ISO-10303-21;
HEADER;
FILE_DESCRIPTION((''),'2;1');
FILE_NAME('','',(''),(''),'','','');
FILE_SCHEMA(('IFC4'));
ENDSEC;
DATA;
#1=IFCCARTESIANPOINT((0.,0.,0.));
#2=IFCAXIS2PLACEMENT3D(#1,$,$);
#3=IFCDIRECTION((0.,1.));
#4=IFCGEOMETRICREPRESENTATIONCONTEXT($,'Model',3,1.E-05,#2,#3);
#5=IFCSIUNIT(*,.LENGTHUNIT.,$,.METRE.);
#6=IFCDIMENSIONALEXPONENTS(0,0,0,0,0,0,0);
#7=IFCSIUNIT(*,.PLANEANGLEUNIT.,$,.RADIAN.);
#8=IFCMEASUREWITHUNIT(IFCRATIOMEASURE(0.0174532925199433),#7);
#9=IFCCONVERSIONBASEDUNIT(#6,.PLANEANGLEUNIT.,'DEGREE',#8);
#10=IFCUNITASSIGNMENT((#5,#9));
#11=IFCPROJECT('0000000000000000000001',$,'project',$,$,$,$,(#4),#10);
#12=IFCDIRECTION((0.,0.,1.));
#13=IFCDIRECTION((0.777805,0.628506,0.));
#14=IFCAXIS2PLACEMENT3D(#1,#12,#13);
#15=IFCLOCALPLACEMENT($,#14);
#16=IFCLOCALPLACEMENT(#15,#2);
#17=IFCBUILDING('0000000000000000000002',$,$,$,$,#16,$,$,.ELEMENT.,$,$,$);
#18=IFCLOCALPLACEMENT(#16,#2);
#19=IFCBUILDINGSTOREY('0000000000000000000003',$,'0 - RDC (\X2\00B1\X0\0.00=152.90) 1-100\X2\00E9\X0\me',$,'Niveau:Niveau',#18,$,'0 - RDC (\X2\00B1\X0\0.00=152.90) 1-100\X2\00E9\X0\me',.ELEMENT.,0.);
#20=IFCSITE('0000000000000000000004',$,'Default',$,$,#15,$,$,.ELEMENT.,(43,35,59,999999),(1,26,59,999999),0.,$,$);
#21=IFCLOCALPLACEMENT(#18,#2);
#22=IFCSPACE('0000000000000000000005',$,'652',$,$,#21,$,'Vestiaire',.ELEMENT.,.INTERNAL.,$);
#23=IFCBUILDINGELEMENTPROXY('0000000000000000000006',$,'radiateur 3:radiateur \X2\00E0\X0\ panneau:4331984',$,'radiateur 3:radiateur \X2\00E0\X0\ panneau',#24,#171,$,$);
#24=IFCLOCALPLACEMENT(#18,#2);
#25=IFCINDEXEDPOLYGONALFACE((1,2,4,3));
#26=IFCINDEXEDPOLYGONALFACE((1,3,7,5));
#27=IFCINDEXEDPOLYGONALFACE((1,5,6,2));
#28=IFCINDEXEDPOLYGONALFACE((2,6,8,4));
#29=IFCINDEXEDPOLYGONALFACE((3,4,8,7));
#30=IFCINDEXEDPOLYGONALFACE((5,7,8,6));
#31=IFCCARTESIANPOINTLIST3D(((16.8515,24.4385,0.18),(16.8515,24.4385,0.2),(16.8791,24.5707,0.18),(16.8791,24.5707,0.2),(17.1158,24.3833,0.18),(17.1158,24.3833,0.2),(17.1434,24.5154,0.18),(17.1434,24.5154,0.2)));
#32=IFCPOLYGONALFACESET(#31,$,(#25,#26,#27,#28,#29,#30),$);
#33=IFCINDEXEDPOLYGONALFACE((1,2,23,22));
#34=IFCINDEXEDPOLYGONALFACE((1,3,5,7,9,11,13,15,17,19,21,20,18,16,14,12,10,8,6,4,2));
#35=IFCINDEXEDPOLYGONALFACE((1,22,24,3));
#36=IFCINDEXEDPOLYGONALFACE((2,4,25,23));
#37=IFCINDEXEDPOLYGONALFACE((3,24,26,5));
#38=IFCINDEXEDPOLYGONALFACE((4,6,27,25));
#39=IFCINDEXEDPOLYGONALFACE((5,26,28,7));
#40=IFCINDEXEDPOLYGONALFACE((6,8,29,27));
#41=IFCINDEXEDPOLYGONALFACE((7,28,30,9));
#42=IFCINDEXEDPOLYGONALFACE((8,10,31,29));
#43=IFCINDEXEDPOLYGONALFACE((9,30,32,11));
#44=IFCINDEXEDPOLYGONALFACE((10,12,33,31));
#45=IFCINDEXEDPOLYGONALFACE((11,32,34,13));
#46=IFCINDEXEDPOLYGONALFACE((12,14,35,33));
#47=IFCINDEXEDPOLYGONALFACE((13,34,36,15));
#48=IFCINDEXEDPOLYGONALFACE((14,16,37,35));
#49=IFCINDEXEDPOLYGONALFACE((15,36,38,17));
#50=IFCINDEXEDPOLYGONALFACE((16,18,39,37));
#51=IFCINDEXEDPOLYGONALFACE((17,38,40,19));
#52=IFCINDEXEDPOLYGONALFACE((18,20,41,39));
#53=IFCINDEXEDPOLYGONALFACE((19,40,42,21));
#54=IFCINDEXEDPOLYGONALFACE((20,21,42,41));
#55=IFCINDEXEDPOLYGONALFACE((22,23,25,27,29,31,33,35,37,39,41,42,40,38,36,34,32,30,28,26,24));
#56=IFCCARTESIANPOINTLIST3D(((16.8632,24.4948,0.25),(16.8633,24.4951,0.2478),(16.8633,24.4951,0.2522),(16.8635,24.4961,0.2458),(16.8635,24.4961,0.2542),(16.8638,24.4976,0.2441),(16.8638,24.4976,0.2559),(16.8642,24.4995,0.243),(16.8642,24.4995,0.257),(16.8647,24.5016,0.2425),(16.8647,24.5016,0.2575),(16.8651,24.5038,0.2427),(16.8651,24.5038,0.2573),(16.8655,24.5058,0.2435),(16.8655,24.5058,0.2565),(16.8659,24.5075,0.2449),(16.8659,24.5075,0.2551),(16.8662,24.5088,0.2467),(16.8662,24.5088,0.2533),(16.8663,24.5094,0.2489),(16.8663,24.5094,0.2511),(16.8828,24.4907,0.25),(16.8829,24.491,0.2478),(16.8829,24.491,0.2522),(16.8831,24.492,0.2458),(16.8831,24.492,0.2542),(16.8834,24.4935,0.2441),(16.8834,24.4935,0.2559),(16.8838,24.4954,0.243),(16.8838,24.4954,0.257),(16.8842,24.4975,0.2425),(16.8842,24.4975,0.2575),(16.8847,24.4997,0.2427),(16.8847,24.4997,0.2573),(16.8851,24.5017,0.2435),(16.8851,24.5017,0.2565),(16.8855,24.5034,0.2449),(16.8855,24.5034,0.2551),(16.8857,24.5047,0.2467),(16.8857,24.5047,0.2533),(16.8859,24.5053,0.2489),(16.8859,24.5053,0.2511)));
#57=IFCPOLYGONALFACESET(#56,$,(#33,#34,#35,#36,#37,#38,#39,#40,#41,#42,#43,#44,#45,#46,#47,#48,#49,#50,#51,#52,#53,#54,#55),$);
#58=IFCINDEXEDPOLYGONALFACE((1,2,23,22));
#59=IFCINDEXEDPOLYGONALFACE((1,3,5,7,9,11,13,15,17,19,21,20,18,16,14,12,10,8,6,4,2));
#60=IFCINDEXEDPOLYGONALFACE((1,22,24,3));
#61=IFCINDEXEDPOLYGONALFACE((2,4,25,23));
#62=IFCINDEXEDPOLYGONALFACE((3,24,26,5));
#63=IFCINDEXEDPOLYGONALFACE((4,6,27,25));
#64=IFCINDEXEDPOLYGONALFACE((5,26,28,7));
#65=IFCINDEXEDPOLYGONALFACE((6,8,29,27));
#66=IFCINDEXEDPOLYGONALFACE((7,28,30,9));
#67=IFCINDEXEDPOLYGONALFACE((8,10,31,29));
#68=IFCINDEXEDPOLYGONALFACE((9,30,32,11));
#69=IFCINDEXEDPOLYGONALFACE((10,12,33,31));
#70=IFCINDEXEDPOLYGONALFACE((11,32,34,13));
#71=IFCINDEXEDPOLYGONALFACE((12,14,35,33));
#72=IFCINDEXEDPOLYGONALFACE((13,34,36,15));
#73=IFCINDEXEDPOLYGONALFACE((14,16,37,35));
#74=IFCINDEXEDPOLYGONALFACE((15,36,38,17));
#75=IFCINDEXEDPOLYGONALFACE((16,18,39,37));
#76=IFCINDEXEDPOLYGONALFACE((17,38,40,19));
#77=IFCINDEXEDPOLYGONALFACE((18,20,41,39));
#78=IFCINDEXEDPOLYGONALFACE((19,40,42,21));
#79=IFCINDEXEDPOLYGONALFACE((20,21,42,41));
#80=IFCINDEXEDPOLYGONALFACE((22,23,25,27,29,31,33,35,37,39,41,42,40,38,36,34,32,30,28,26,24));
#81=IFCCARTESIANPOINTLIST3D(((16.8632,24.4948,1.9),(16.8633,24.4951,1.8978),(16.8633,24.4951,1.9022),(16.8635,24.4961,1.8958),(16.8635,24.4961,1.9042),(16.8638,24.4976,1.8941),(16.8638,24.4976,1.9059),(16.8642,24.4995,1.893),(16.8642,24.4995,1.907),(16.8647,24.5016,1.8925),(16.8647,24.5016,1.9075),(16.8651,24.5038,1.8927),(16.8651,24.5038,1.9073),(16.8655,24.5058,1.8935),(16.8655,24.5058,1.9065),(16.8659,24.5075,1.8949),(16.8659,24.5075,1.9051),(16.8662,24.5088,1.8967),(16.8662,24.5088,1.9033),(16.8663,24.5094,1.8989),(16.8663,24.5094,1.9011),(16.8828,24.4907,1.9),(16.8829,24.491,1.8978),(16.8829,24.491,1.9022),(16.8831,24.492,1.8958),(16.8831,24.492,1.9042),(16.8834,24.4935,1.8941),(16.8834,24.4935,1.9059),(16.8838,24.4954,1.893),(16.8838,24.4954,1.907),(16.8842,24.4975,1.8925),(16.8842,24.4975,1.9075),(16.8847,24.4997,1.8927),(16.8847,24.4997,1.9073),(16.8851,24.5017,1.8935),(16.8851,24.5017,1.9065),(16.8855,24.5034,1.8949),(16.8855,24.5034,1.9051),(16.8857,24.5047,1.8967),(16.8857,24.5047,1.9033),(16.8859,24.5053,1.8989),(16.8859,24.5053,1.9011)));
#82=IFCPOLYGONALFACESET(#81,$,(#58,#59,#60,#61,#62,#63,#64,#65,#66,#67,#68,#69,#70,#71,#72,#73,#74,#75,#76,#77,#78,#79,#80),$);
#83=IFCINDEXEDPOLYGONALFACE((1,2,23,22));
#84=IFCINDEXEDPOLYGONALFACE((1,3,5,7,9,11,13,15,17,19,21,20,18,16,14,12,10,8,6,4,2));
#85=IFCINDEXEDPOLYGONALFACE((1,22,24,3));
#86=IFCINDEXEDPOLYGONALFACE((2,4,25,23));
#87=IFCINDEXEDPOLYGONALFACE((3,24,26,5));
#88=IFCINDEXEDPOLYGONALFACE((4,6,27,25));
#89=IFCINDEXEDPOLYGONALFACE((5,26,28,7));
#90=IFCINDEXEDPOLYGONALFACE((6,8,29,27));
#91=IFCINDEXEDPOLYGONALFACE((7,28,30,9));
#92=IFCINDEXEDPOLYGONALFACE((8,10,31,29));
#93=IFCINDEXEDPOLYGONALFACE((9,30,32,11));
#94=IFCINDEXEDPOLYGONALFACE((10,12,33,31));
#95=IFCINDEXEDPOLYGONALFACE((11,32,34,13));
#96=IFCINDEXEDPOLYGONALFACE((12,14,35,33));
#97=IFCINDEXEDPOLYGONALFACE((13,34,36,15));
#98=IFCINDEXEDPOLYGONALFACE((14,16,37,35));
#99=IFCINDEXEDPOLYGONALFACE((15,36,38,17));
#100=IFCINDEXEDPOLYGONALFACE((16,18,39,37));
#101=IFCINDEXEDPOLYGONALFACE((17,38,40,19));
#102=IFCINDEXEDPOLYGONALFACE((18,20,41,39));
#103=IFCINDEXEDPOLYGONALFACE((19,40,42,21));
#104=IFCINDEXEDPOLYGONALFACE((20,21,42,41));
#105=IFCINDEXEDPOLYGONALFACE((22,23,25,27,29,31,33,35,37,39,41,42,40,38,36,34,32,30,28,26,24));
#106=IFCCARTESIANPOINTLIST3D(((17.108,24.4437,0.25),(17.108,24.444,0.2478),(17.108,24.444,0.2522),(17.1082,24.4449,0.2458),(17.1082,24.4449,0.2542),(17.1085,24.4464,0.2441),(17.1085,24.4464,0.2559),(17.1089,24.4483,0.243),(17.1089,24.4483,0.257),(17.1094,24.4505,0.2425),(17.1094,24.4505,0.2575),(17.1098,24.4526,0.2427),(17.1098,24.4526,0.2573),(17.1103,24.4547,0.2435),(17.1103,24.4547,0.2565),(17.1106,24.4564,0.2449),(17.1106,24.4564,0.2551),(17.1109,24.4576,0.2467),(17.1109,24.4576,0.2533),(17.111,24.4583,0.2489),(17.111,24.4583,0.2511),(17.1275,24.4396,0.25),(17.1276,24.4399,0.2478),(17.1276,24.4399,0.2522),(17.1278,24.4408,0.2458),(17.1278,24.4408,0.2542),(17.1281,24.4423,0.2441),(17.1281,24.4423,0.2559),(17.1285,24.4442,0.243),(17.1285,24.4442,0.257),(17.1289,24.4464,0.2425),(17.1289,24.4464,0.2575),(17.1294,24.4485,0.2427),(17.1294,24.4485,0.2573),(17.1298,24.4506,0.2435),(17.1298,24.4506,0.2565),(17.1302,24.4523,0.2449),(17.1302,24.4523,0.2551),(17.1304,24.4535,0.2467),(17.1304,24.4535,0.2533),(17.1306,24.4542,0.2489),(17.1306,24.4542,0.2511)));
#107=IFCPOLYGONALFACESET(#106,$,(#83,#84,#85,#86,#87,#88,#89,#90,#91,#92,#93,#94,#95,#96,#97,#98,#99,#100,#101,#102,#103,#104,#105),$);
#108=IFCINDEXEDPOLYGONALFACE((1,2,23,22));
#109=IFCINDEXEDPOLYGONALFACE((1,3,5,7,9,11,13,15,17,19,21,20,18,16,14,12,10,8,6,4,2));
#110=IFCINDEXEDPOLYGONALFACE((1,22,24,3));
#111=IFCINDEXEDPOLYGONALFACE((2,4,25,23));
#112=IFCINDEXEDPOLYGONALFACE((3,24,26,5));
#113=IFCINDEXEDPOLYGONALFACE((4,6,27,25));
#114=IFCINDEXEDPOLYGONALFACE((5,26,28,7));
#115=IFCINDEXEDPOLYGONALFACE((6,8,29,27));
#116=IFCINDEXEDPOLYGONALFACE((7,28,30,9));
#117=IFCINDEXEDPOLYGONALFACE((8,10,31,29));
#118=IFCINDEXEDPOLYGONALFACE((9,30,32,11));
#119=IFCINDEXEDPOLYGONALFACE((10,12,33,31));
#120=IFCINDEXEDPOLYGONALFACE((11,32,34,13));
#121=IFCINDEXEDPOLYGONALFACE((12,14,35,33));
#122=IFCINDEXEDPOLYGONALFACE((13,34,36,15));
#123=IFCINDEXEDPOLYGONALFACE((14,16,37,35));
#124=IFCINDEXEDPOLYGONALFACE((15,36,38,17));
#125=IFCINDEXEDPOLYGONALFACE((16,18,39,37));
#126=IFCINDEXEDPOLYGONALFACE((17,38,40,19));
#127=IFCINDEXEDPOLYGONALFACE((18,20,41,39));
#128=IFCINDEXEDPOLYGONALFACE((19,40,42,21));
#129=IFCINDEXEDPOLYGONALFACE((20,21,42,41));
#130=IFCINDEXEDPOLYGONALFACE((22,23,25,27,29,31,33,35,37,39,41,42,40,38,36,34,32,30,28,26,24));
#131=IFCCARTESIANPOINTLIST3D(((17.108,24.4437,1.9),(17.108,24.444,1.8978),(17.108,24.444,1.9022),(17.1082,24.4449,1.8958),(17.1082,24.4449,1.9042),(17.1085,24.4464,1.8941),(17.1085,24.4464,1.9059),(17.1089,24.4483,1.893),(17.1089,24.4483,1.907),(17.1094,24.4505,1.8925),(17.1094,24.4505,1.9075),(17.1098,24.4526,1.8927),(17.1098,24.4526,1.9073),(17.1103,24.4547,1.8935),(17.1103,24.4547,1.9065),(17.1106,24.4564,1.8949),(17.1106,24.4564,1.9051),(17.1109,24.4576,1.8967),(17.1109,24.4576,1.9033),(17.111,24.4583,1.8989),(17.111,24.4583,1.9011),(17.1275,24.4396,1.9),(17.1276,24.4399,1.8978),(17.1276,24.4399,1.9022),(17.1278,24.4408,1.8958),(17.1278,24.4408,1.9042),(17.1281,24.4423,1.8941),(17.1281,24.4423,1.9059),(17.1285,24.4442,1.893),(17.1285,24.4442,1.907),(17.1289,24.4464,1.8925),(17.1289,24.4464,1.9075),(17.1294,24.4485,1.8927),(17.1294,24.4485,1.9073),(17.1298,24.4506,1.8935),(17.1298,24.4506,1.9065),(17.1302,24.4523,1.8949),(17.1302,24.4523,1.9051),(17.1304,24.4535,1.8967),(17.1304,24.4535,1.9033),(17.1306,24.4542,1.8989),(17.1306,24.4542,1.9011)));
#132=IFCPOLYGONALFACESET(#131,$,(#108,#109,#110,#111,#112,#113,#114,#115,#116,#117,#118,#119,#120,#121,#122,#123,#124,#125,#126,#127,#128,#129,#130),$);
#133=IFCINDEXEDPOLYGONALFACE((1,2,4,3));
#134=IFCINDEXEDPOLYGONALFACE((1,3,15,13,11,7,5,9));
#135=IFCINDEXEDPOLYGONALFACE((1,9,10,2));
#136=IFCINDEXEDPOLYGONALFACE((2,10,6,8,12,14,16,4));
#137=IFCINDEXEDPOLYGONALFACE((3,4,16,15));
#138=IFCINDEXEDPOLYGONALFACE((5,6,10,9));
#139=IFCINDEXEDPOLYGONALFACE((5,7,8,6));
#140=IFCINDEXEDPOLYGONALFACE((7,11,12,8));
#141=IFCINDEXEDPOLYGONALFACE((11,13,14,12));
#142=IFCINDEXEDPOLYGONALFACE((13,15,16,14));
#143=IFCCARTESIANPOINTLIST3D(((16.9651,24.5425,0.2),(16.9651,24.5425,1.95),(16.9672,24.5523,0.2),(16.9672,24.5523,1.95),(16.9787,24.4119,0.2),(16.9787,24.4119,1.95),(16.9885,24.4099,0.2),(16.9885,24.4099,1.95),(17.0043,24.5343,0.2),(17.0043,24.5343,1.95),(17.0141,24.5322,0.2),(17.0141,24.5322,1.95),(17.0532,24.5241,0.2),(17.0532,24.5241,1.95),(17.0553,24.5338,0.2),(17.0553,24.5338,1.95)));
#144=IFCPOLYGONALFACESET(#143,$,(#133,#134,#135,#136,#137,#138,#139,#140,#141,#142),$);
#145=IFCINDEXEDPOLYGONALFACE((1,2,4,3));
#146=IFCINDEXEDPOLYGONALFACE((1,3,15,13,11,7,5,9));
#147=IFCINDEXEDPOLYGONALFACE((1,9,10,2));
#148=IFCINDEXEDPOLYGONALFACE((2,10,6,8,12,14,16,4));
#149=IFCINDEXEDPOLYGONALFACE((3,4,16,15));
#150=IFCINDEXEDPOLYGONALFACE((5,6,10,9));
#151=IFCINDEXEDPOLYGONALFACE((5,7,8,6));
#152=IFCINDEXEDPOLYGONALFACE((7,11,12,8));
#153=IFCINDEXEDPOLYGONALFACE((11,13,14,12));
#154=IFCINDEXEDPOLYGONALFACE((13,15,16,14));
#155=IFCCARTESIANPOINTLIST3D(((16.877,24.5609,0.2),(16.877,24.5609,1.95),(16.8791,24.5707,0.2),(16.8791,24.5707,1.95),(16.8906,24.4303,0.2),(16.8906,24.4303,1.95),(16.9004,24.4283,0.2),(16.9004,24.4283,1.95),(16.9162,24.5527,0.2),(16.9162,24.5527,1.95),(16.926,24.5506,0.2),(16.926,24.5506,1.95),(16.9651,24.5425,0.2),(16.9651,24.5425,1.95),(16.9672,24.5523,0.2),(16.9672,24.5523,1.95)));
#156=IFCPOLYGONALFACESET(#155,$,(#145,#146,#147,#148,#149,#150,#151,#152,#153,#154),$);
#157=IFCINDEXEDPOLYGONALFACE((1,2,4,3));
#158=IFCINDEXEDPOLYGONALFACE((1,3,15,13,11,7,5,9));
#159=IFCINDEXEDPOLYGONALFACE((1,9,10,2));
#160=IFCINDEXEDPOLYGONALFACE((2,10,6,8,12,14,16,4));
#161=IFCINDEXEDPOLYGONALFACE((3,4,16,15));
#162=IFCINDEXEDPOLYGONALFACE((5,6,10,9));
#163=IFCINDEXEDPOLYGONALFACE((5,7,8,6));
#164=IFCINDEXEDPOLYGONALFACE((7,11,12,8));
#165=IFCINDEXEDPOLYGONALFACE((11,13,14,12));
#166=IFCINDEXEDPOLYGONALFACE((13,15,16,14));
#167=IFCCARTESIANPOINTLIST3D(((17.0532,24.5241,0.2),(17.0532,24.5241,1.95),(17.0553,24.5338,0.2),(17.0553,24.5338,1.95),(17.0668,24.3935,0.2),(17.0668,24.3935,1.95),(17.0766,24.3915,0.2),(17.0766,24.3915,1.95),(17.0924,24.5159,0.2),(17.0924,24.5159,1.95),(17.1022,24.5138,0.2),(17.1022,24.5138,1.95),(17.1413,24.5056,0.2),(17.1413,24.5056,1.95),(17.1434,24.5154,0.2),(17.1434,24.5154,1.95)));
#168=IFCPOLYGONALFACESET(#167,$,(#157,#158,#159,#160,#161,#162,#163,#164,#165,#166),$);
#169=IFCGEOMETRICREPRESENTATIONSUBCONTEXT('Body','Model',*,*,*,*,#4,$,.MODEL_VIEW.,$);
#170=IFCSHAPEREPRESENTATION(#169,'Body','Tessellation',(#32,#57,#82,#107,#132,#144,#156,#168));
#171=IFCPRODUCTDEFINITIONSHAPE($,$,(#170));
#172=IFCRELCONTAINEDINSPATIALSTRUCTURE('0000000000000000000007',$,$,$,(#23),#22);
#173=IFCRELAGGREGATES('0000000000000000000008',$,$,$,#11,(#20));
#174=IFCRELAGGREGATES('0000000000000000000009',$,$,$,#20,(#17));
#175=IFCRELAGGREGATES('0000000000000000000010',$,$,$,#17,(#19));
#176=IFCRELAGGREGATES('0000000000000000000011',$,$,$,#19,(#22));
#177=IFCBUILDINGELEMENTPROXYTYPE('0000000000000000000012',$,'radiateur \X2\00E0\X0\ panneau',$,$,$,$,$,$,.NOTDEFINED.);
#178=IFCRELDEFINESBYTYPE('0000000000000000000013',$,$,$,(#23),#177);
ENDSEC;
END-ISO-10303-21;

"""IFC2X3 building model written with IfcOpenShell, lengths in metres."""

from ifc_helpers import new_model, entity, si_unit, converted_unit, direction, frame, frame_2d, origin, origin_2d_with_axis, place, context, subcontext, project, spatial, polyline, rectangle, circle, outline, extrude, source, transform, mapped, type_object, type_shapes, element, save


model = new_model("IFC2X3")

# Units and contexts
model_context = context("Model", 3, precision=1e-05, world=origin(), true_north=direction((0.0, 1.0)))
body_context = subcontext(model_context, "Body", "Model", "MODEL_VIEW")
ifc_project = project(units=[si_unit("LENGTHUNIT", "METRE"), converted_unit("PLANEANGLEUNIT", "DEGREE", entity("IfcRatioMeasure", 0.0174532925199433), si_unit("PLANEANGLEUNIT", "RADIAN"), dimensions=[0, 0, 0, 0, 0, 0, 0])], contexts=[model_context])

# Site, building, storey
site_placement = place(None, frame((0.0, 0.0, 0.0), z_axis=(0.0, 0.0, 1.0), x_axis=(0.777805, 0.628506, 0.0)))
site = spatial("IfcSite", under=ifc_project, at=site_placement, Name="Default", CompositionType="ELEMENT", RefLatitude=(43, 35, 59, 999999), RefLongitude=(1, 26, 59, 999999), RefElevation=0.0)
building_placement = place(site_placement, origin())
building = spatial("IfcBuilding", under=site, at=building_placement, CompositionType="ELEMENT")
storey_placement = place(building_placement, origin())
storey = spatial("IfcBuildingStorey", under=building, at=storey_placement, Name="0 - RDC (±0.00=152.90) 1-100éme", ObjectType="Niveau:Niveau", LongName="0 - RDC (±0.00=152.90) 1-100éme", CompositionType="ELEMENT", Elevation=0.0)

# Shared definitions
space_1_placement = place(storey_placement, origin())
space_1 = spatial("IfcSpace", under=storey, at=space_1_placement, Name="652", LongName="Vestiaire", CompositionType="ELEMENT", InteriorOrExteriorSpace="INTERNAL")

# Building element proxy
building_element_proxy_type_1 = type_object("IfcBuildingElementProxyType", Name="radiateur à panneau", PredefinedType="NOTDEFINED")
shared_shape_1 = source(origin(), body_context, "Body", "SweptSolid", [
    extrude(rectangle(XDim=0.135, YDim=0.27, at=frame_2d((0.0, 0.0), x_axis=(1.0, 0.0))), frame((0.135, -0.0025, -0.02), z_axis=(0.0, 0.0, 1.0), x_axis=(0.0, -1.0, 0.0)), (0.0, 0.0, 1.0), 0.02),
    extrude(circle(Radius=0.0075, at=frame_2d((0.0, 0.0), x_axis=(1.0, 0.0))), frame((0.25, 0.0, 0.05), z_axis=(1.0, 0.0, 0.0), x_axis=(0.0, 1.0, 0.0)), (0.0, 0.0, 1.0), 0.02),
    extrude(circle(Radius=0.0075, at=frame_2d((0.0, 0.0), x_axis=(1.0, 0.0))), frame((0.25, 0.0, 1.7), z_axis=(1.0, 0.0, 0.0), x_axis=(0.0, 1.0, 0.0)), (0.0, 0.0, 1.0), 0.02),
    extrude(circle(Radius=0.0075, at=frame_2d((0.0, 0.0), x_axis=(1.0, 0.0))), frame((0.0, 0.0, 0.05), z_axis=(1.0, 0.0, 0.0), x_axis=(0.0, 1.0, 0.0)), (0.0, 0.0, 1.0), 0.02),
    extrude(circle(Radius=0.0075, at=origin_2d_with_axis()), frame((0.0, 0.0, 1.7), z_axis=(1.0, 0.0, 0.0), x_axis=(0.0, 1.0, 0.0)), (0.0, 0.0, 1.0), 0.02),
    extrude(outline(polyline([(-0.005, -0.0963), (0.005, -0.0963), (0.005, 0.0288), (0.045, 0.0288), (0.045, 0.0387), (-0.045, 0.0387), (-0.045, 0.0288), (-0.005, 0.0288), (-0.005, -0.0963)])), frame((0.135, -0.0313, 0.0), z_axis=(0.0, 0.0, 1.0), x_axis=(-1.0, 0.0, 0.0)), (0.0, 0.0, 1.0), 1.75),
    extrude(outline(polyline([(-0.005, -0.0963), (0.005, -0.0963), (0.005, 0.0288), (0.045, 0.0288), (0.045, 0.0387), (-0.045, 0.0387), (-0.045, 0.0288), (-0.005, 0.0288), (-0.005, -0.0963)])), frame((0.225, -0.0313, 0.0), z_axis=(0.0, 0.0, 1.0), x_axis=(-1.0, 0.0, 0.0)), (0.0, 0.0, 1.0), 1.75),
    extrude(outline(polyline([(-0.005, -0.0963), (0.005, -0.0963), (0.005, 0.0288), (0.045, 0.0288), (0.045, 0.0387), (-0.045, 0.0387), (-0.045, 0.0288), (-0.005, 0.0288), (-0.005, -0.0963)])), frame((0.045, -0.0313, 0.0), z_axis=(0.0, 0.0, 1.0), x_axis=(-1.0, 0.0, 0.0)), (0.0, 0.0, 1.0), 1.75),
])
type_shapes(building_element_proxy_type_1, [shared_shape_1])
proxy_1_placement = place(space_1_placement, frame((17.1291, 24.4469, 0.2), z_axis=(0.0, 0.0, 1.0), x_axis=(-0.978853, 0.204564, 0.0)))
element("IfcBuildingElementProxy", 1, at=proxy_1_placement, inside=space_1, type_object=building_element_proxy_type_1, Name="radiateur 3:radiateur à panneau:4331984", ObjectType="radiateur 3:radiateur à panneau", context=body_context, shape_type="MappedRepresentation", body=[
    mapped(shared_shape_1, transform((0.0, 0.0, 0.0), scale=1.0)),
])

save(model, "model.ifc")
